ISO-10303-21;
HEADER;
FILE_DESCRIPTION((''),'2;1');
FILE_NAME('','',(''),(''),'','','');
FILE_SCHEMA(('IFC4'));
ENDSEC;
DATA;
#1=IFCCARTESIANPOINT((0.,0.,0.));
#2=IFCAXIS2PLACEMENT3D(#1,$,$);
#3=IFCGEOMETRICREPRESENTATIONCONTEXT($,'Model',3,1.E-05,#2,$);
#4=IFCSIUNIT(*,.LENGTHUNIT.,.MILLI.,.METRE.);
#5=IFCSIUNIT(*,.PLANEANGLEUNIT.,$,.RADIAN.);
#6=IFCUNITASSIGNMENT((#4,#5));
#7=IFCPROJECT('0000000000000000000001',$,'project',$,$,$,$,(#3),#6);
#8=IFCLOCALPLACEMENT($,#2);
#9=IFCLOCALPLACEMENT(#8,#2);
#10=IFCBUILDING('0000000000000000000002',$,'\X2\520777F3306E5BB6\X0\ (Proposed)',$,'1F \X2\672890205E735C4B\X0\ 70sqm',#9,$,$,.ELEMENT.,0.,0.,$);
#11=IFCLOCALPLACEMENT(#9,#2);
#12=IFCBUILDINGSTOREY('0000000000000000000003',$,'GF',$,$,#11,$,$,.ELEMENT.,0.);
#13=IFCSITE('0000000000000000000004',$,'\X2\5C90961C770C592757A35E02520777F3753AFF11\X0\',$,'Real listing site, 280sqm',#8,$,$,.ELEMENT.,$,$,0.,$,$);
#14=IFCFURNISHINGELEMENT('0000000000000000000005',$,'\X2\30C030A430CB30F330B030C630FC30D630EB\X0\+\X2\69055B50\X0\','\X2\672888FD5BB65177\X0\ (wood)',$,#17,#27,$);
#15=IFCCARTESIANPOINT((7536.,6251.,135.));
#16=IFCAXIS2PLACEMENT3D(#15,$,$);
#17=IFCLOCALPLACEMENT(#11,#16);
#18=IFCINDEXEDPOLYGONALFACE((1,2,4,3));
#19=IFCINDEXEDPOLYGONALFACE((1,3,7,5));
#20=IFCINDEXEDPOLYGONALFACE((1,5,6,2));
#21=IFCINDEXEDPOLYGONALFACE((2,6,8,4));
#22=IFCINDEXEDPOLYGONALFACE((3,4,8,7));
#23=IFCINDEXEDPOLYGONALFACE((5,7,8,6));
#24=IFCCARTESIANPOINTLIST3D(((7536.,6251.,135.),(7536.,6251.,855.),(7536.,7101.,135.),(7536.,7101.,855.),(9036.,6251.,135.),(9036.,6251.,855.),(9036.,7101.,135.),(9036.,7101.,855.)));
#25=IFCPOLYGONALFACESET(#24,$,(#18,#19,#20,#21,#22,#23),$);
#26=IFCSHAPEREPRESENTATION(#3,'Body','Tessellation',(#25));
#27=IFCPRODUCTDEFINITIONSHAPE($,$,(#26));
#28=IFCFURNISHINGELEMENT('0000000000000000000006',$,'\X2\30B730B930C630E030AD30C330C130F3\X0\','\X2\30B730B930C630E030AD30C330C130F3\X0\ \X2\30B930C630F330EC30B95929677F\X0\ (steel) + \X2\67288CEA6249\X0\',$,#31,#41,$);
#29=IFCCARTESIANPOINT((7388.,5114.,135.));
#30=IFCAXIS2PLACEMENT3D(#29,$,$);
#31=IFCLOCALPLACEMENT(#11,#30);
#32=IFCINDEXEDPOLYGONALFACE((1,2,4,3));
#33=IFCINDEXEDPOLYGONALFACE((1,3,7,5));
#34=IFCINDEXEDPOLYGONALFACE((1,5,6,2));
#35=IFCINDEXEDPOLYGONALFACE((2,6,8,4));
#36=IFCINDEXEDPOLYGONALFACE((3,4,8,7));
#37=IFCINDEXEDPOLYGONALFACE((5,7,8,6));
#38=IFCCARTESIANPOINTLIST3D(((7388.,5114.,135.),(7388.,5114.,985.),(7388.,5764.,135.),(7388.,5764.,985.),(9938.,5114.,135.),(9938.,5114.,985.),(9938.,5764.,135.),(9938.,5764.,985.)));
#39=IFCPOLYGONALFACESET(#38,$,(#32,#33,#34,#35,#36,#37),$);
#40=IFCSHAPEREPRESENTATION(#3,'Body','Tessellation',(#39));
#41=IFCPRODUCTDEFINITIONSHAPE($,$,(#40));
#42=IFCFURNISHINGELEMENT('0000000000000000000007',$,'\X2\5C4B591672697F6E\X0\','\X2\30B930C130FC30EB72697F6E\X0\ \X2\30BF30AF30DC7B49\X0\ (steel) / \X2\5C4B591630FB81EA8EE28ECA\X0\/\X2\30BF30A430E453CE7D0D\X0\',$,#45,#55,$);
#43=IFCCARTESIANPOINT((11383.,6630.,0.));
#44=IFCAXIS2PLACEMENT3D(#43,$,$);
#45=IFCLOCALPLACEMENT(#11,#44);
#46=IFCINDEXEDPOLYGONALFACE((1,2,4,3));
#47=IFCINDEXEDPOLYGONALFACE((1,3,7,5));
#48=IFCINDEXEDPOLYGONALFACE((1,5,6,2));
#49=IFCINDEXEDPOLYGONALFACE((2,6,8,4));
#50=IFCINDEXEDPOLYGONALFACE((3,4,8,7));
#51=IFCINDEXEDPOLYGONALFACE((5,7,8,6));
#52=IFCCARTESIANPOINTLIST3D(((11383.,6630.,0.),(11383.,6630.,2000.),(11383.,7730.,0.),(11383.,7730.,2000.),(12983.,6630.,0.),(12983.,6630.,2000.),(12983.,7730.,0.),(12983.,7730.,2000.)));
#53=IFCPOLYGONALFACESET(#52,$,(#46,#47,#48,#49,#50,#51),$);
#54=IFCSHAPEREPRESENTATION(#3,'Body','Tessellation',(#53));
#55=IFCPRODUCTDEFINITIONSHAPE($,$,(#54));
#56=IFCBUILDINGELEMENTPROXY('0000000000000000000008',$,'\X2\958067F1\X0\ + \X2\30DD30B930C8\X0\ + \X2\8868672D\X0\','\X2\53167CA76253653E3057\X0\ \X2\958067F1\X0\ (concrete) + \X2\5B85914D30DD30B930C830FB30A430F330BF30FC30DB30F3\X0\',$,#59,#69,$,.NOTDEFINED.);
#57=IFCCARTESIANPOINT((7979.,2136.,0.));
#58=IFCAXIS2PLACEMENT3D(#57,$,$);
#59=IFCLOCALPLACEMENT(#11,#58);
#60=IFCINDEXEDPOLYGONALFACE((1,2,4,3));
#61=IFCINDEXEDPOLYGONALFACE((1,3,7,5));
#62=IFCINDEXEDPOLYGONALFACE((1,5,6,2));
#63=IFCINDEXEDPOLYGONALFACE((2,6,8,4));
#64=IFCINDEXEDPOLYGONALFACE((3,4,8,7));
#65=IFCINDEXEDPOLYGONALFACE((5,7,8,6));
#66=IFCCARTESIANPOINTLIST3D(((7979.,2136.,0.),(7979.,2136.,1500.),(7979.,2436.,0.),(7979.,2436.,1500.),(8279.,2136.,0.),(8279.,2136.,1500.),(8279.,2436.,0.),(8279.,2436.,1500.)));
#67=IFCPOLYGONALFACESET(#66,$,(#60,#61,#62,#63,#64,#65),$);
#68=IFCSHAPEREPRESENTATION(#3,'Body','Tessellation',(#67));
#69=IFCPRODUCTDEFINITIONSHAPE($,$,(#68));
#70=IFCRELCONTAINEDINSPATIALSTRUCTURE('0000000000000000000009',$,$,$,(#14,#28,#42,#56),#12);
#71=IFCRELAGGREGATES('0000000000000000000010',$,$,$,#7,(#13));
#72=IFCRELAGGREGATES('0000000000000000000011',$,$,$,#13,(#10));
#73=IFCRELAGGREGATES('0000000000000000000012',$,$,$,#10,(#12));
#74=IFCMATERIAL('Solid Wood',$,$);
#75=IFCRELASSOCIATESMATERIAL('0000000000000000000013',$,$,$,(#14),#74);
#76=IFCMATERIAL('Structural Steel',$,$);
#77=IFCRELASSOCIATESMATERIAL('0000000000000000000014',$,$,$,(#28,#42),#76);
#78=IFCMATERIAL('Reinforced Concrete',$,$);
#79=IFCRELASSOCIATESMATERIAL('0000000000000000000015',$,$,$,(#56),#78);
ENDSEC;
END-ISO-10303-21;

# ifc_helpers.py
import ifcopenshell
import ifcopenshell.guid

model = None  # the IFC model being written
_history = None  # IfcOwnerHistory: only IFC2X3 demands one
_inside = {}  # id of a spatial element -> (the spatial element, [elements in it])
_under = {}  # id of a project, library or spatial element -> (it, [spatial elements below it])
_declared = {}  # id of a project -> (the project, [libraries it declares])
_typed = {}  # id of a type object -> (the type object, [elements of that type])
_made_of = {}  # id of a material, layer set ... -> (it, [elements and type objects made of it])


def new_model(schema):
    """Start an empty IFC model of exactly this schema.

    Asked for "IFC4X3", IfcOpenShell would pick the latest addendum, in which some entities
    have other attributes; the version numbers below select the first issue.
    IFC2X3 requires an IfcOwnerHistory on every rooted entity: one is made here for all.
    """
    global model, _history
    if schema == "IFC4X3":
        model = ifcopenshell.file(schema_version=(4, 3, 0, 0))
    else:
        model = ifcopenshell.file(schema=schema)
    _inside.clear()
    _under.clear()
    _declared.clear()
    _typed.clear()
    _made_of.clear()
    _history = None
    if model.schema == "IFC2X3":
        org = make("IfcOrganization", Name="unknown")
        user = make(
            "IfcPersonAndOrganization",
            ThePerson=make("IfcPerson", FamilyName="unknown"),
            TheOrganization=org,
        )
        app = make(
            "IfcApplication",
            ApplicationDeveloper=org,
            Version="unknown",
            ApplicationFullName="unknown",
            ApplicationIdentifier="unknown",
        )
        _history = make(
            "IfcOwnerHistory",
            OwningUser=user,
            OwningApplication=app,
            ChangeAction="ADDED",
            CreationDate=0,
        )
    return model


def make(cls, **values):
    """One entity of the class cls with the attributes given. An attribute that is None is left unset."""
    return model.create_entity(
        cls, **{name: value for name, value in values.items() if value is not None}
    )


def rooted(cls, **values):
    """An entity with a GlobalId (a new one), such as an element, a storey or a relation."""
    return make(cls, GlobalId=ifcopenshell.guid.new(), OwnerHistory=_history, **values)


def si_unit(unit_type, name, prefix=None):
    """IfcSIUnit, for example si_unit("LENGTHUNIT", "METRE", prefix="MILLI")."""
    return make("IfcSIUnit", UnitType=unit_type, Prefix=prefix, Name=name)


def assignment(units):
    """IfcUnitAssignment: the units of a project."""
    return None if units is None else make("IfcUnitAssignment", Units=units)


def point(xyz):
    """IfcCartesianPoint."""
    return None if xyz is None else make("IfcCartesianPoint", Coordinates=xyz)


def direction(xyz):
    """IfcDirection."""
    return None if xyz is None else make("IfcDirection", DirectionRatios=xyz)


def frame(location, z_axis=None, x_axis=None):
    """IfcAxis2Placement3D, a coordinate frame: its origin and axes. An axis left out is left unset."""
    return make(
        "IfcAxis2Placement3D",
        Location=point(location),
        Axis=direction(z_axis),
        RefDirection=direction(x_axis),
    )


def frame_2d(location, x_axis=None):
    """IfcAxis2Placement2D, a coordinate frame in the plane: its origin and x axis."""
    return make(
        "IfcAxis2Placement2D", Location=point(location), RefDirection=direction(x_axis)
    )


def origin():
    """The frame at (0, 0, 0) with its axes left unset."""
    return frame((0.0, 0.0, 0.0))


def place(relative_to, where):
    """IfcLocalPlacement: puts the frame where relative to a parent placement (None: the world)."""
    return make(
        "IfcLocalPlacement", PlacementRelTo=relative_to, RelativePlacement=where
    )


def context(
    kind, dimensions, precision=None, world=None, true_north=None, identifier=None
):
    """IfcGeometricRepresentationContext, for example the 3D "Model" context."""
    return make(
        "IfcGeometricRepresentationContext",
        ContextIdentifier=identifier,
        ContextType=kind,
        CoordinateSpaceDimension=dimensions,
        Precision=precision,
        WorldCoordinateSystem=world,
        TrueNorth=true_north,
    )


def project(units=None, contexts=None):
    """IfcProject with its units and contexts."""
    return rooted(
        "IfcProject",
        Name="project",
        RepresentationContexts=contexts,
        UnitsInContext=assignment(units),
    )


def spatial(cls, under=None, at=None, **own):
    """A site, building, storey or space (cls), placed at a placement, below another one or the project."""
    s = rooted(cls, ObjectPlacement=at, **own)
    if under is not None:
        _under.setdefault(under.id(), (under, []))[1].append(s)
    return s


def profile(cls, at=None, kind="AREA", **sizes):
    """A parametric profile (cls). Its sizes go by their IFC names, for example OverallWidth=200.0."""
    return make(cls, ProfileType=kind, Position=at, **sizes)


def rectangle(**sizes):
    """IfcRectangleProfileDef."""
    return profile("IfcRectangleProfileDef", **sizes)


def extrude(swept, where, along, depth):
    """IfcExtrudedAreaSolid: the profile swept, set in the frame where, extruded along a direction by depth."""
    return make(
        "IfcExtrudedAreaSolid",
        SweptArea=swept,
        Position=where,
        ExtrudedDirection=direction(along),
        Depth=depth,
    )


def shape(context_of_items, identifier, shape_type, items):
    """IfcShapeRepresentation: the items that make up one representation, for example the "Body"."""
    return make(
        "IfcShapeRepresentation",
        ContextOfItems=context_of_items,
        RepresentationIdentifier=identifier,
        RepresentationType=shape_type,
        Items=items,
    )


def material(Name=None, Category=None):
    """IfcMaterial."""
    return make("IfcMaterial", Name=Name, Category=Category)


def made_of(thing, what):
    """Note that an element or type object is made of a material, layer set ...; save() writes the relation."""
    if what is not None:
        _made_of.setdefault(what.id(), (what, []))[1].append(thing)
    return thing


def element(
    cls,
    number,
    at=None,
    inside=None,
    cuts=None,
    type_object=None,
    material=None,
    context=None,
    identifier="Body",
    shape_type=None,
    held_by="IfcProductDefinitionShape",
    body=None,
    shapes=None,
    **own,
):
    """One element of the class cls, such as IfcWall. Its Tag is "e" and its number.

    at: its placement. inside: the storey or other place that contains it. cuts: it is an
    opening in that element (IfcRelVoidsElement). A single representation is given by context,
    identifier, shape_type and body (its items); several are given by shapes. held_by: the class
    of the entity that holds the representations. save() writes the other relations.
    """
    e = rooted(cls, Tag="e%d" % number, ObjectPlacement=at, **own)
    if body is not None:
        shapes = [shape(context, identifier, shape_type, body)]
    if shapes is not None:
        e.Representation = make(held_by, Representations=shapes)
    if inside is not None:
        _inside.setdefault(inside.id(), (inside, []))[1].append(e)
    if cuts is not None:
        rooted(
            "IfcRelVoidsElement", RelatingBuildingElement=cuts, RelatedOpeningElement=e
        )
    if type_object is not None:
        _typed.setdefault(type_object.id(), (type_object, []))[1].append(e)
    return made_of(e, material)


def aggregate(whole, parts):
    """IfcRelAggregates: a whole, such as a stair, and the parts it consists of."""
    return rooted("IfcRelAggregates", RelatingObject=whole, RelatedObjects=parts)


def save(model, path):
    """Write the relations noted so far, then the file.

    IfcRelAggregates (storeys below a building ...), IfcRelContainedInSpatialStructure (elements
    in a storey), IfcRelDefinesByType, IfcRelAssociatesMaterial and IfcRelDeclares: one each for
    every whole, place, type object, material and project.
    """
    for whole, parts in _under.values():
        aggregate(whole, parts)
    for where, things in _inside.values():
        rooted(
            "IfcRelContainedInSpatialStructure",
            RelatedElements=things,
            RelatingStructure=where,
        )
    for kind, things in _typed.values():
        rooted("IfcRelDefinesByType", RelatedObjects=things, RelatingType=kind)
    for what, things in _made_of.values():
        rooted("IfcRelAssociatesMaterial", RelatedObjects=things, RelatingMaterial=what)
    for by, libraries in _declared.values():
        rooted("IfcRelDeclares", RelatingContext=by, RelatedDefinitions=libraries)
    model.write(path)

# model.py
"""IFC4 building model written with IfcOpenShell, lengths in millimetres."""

from ifc_helpers import new_model, si_unit, frame, frame_2d, origin, place, context, project, spatial, rectangle, extrude, material, element, save


model = new_model("IFC4")

# Units and contexts
model_context = context("Model", 3, precision=1e-05, world=origin())
ifc_project = project(units=[si_unit("LENGTHUNIT", "METRE", prefix="MILLI"), si_unit("PLANEANGLEUNIT", "RADIAN")], contexts=[model_context])

# Site, building, storey
site_placement = place(None, origin())
site = spatial("IfcSite", under=ifc_project, at=site_placement, Name="岐阜県大垣市切石町１", ObjectType="Real listing site, 280sqm", CompositionType="ELEMENT", RefElevation=0.0)
building_placement = place(site_placement, origin())
building = spatial("IfcBuilding", under=site, at=building_placement, Name="切石の家 (Proposed)", ObjectType="1F 木造平屋 70sqm", CompositionType="ELEMENT", ElevationOfRefHeight=0.0, ElevationOfTerrain=0.0)
storey_placement = place(building_placement, origin())
storey = spatial("IfcBuildingStorey", under=building, at=storey_placement, Name="GF", CompositionType="ELEMENT", Elevation=0.0)

# Shared definitions
ifc_material_1 = material(Name="Solid Wood")

# Shared definitions
ifc_material_2 = material(Name="Structural Steel")

# Shared definitions
ifc_material_3 = material(Name="Reinforced Concrete")

# Furnishing elements
furnishing_1_placement = place(storey_placement, frame((7536.0, 6251.0, 135.0)))
element("IfcFurnishingElement", 1, at=furnishing_1_placement, inside=storey, material=ifc_material_1, Name="ダイニングテーブル+椅子", Description="木製家具 (wood)", context=model_context, shape_type="SweptSolid", body=[
    extrude(rectangle(XDim=1500.0, YDim=850.0, at=frame_2d((750.0, 425.0))), frame((7536.0, 6251.0, 135.0)), (0.0, 0.0, 1.0), 720.0),
])
furnishing_2_placement = place(storey_placement, frame((7388.0, 5114.0, 135.0)))
element("IfcFurnishingElement", 2, at=furnishing_2_placement, inside=storey, material=ifc_material_2, Name="システムキッチン", Description="システムキッチン ステンレス天板 (steel) + 木質扉", context=model_context, shape_type="SweptSolid", body=[
    extrude(rectangle(XDim=2550.0, YDim=650.0, at=frame_2d((1275.0, 325.0))), frame((7388.0, 5114.0, 135.0)), (0.0, 0.0, 1.0), 850.0),
])
furnishing_3_placement = place(storey_placement, frame((11383.0, 6630.0, 0.0)))
element("IfcFurnishingElement", 3, at=furnishing_3_placement, inside=storey, material=ifc_material_2, Name="屋外物置", Description="スチール物置 タクボ等 (steel) / 屋外・自転車/タイヤ収納", context=model_context, shape_type="SweptSolid", body=[
    extrude(rectangle(XDim=1600.0, YDim=1100.0, at=frame_2d((800.0, 550.0))), frame((11383.0, 6630.0, 0.0)), (0.0, 0.0, 1.0), 2000.0),
])

# Building element proxy
proxy_placement = place(storey_placement, frame((7979.0, 2136.0, 0.0)))
element("IfcBuildingElementProxy", 4, at=proxy_placement, inside=storey, material=ifc_material_3, Name="門柱 + ポスト + 表札", Description="化粧打放し 門柱 (concrete) + 宅配ポスト・インターホン", PredefinedType="NOTDEFINED", context=model_context, shape_type="SweptSolid", body=[
    extrude(rectangle(XDim=300.0, YDim=300.0, at=frame_2d((150.0, 150.0))), frame((7979.0, 2136.0, 0.0)), (0.0, 0.0, 1.0), 1500.0),
])

save(model, "model.ifc")
